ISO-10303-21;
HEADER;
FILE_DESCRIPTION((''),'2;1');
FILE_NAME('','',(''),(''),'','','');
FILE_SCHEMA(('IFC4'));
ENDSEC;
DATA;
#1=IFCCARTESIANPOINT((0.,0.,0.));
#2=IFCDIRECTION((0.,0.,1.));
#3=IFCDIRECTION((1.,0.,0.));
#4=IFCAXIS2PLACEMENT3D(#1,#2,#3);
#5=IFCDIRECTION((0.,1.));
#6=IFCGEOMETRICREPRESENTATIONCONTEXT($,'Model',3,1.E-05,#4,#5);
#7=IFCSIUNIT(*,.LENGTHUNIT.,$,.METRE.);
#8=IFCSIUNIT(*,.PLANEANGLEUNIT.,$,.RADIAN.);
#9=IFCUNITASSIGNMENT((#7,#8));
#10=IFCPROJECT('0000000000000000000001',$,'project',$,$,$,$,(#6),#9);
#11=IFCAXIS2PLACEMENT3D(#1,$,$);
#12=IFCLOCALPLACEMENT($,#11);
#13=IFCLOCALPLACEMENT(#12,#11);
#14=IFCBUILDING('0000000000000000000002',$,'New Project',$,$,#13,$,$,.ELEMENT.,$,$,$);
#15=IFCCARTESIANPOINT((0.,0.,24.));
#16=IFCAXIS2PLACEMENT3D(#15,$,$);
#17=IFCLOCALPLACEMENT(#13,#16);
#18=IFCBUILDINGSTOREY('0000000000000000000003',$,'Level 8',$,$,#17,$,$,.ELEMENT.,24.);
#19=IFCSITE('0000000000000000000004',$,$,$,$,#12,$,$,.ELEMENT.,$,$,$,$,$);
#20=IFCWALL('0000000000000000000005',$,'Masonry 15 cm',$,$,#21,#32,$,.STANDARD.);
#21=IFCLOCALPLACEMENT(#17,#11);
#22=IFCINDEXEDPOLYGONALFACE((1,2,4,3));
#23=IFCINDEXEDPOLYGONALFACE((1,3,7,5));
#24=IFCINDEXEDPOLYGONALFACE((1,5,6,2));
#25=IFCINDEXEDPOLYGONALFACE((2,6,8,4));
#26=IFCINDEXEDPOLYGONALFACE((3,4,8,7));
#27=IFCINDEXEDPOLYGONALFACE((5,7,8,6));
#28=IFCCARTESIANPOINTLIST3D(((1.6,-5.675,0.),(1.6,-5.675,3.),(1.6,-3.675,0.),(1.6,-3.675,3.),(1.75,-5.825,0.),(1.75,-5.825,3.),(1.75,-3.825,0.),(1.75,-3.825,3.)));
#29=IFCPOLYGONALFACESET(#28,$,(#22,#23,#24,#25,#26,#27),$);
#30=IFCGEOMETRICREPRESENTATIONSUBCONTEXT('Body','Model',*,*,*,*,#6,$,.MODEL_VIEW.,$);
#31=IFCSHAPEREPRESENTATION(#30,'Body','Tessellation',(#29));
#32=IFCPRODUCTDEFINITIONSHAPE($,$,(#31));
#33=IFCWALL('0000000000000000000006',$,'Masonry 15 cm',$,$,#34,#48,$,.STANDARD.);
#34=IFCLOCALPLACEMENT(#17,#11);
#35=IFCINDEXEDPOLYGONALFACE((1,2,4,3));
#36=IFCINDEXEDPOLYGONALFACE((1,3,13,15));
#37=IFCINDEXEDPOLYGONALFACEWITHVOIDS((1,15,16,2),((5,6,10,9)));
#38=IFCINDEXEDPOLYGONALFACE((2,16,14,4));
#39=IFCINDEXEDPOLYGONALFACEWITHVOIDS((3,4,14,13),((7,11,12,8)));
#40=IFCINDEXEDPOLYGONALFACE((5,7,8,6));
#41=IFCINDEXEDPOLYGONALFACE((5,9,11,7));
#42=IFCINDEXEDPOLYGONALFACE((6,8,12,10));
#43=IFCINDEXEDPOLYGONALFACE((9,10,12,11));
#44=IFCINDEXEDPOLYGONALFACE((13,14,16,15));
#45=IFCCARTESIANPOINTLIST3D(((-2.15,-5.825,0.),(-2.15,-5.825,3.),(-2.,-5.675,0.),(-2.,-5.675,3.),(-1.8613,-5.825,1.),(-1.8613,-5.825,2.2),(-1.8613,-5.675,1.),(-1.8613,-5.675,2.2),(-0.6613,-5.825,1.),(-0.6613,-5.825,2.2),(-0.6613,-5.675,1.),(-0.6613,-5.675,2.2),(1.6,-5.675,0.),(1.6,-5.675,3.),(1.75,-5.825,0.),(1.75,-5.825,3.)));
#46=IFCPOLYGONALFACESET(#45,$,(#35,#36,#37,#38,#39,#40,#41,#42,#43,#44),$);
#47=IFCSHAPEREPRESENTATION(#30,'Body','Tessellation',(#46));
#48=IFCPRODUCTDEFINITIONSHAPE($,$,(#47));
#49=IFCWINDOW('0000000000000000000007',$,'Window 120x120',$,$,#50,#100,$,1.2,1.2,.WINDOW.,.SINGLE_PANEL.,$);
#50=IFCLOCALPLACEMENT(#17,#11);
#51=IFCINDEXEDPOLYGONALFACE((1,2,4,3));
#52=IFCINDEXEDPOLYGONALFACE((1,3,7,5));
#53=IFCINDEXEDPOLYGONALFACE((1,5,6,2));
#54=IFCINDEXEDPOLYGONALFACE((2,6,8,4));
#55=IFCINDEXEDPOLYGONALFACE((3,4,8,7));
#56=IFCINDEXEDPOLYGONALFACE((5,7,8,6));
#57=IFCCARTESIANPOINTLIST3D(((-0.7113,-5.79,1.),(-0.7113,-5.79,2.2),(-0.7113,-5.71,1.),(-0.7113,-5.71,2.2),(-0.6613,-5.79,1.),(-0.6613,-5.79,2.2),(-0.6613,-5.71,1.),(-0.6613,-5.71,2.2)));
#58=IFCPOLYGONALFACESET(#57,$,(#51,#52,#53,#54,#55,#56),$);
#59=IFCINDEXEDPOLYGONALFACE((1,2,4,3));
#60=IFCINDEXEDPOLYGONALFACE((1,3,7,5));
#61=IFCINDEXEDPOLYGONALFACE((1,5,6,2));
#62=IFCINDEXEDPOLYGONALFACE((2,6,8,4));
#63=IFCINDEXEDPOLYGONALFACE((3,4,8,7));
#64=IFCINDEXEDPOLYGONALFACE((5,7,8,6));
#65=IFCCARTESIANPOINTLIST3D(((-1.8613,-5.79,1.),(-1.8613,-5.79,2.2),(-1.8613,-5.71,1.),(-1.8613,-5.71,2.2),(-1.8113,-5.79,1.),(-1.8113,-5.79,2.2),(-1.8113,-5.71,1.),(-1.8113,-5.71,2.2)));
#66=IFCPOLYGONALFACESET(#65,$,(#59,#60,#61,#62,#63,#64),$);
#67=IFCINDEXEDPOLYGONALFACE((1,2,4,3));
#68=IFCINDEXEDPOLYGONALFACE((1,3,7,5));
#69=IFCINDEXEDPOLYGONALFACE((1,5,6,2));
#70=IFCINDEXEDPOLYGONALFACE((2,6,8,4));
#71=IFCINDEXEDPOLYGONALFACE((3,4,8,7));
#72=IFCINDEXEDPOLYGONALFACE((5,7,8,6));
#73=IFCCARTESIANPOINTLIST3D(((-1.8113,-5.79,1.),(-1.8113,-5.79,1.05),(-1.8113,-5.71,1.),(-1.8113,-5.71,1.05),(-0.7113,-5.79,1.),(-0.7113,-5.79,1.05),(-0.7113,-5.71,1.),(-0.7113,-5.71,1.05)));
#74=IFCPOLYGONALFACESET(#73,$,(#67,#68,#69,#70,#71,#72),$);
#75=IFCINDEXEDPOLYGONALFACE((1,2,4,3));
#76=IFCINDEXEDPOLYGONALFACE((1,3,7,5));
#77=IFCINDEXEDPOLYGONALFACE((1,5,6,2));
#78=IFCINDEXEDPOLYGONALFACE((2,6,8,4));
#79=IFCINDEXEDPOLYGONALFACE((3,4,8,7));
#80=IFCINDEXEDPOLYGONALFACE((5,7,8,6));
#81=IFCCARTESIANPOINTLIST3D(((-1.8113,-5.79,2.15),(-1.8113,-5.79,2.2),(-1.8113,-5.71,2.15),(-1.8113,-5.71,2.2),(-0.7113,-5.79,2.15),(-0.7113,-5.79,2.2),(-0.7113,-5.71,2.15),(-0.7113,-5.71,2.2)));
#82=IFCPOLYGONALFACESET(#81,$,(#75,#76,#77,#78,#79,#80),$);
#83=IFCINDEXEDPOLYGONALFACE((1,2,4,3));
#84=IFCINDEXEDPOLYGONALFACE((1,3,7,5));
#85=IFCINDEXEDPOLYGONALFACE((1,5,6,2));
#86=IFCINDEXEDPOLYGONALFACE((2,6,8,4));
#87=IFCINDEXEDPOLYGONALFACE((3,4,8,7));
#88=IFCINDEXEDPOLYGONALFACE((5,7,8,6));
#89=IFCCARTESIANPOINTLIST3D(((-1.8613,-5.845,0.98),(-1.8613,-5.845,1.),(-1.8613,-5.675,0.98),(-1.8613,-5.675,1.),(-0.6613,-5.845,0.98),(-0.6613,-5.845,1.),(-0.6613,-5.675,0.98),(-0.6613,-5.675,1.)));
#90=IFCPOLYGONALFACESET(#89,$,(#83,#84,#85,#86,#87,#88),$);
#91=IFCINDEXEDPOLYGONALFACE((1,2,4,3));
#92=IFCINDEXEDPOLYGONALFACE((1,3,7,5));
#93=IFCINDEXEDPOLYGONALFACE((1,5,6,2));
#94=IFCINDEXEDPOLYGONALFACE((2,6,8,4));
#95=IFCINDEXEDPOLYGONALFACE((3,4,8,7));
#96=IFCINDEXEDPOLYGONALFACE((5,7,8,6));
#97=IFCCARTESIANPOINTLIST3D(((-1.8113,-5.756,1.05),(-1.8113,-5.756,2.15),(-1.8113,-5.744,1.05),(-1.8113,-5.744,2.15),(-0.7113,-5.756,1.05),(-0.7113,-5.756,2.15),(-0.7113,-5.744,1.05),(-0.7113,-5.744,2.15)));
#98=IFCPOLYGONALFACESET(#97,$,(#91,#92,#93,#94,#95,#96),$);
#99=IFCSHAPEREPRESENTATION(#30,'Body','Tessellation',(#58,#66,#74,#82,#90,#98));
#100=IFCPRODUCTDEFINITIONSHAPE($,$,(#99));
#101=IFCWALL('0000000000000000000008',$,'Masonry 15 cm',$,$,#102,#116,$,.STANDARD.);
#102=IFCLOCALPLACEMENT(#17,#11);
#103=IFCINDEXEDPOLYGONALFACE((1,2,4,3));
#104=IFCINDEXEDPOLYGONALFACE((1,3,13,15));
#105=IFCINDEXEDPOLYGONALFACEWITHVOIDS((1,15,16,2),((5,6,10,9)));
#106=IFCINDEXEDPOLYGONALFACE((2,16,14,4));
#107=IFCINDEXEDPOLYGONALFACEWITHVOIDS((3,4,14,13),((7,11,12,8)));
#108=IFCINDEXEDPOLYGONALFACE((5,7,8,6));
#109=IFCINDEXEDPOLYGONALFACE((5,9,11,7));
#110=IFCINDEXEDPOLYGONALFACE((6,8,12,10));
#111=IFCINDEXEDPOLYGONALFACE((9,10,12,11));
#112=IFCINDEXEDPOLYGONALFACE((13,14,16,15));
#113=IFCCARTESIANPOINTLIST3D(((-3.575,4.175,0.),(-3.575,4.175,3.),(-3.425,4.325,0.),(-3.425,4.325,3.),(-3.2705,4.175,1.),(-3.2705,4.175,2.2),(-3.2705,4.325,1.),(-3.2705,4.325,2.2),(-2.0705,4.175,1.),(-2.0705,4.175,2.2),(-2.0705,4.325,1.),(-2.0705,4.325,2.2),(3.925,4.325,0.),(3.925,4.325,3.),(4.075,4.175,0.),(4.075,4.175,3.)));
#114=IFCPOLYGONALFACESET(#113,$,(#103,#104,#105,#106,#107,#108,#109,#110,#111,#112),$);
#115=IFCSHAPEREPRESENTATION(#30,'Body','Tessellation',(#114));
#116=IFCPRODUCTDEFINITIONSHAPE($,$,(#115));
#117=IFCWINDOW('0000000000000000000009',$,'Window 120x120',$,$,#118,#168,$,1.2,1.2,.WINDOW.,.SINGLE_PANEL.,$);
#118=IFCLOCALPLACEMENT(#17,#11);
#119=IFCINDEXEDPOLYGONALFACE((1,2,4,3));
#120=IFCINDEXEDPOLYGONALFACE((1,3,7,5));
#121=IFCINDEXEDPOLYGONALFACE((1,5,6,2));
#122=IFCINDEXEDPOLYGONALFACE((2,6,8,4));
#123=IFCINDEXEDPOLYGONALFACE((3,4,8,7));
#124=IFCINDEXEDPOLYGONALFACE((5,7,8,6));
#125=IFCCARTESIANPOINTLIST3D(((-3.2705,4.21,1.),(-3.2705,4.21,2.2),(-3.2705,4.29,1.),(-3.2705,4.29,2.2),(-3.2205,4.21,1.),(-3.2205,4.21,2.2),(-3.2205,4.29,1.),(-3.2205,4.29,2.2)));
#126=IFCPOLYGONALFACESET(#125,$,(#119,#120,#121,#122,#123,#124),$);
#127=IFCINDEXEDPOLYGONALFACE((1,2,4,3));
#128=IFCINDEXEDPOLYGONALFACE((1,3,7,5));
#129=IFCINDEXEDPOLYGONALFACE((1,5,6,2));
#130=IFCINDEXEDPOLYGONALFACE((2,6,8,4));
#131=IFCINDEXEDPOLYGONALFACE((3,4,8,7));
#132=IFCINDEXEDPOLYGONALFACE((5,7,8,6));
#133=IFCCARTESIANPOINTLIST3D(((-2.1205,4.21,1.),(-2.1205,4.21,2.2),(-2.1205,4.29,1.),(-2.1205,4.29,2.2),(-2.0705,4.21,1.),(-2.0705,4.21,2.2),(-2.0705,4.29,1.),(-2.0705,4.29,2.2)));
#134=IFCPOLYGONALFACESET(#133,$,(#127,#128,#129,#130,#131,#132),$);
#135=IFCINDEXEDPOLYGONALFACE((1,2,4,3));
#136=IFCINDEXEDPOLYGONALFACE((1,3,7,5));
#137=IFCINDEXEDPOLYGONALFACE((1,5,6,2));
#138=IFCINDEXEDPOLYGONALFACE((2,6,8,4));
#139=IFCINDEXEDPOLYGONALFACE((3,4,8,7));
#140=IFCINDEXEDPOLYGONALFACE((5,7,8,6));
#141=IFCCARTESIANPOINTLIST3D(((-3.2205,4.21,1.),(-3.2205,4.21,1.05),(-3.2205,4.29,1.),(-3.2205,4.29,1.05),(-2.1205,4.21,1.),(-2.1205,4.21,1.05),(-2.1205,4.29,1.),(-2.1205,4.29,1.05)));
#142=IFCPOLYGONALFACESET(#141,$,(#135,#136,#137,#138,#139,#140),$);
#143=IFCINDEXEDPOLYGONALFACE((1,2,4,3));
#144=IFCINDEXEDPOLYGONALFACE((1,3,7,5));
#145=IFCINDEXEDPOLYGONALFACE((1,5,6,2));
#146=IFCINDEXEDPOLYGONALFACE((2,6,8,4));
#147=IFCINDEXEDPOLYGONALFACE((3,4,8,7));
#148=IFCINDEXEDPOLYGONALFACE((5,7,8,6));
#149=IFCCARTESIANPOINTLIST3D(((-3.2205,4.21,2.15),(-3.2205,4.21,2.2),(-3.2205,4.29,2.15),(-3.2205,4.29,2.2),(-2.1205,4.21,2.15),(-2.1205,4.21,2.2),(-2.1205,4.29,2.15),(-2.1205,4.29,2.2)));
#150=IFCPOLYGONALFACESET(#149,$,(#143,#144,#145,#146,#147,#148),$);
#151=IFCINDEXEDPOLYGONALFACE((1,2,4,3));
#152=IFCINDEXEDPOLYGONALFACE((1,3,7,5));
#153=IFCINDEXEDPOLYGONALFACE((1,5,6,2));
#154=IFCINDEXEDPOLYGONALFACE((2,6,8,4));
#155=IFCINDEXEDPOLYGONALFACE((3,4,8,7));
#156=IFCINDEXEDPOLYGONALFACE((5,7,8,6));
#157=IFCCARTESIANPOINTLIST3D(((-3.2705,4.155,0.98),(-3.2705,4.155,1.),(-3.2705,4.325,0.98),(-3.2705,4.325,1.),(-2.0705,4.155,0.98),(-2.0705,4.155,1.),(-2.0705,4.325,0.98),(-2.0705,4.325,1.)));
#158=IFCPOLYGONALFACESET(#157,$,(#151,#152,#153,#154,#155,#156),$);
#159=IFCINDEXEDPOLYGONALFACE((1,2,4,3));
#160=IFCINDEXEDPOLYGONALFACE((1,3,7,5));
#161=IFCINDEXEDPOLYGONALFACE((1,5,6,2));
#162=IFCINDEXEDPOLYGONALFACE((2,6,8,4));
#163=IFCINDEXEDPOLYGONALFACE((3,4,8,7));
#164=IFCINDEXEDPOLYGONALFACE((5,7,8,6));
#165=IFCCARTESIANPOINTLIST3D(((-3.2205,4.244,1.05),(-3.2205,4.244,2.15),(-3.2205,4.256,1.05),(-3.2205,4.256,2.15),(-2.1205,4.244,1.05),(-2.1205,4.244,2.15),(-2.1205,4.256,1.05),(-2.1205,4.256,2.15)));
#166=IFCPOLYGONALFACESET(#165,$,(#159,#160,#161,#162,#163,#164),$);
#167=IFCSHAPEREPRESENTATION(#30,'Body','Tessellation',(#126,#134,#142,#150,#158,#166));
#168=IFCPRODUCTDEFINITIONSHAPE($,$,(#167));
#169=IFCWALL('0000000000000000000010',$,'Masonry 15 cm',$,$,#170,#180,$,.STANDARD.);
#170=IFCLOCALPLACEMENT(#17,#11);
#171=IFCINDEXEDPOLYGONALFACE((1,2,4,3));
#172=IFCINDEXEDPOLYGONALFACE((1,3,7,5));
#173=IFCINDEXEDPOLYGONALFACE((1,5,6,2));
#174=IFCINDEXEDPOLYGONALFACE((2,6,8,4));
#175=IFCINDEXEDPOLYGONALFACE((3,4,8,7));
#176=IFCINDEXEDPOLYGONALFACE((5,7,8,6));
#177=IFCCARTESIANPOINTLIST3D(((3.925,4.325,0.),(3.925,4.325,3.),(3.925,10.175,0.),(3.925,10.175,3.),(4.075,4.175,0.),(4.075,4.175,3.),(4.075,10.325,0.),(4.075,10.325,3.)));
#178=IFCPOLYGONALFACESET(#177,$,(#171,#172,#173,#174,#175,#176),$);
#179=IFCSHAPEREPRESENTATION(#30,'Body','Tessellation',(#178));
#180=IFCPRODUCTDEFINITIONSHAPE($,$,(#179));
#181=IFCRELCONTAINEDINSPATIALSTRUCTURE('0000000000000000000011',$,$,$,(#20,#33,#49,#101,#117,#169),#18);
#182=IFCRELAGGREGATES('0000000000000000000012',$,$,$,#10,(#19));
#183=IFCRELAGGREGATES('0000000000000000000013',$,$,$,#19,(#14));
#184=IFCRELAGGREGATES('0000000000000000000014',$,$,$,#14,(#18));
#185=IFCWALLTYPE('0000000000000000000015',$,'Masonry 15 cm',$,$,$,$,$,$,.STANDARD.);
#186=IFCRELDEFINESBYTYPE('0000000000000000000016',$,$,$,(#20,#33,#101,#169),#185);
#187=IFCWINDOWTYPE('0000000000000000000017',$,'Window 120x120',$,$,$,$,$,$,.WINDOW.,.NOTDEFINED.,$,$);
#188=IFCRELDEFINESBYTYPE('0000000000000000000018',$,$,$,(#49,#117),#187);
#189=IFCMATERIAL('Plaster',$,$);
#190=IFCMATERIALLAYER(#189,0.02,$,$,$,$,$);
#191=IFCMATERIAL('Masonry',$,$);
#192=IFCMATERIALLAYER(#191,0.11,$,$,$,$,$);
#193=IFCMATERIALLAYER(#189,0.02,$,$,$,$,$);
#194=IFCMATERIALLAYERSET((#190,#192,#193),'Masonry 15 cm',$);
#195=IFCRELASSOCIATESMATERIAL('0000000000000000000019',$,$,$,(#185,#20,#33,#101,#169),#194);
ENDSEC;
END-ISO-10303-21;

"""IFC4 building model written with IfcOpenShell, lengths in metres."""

from ifc_helpers import new_model, si_unit, direction, frame, frame_2d, origin, origin_with_axes, place, context, subcontext, project, spatial, polyline, rectangle, outline, extrude, material, layer, layer_set, layer_usage, type_object, element, fill, save


model = new_model("IFC4")

# Units and contexts
model_context = context("Model", 3, precision=1e-05, world=origin_with_axes(), true_north=direction((0.0, 1.0)))
body_context = subcontext(model_context, "Body", "Model", "MODEL_VIEW")
ifc_project = project(units=[si_unit("LENGTHUNIT", "METRE"), si_unit("PLANEANGLEUNIT", "RADIAN")], contexts=[model_context])

# Site, building, storey
site_placement = place(None, origin())
site = spatial("IfcSite", under=ifc_project, at=site_placement, CompositionType="ELEMENT")
building_placement = place(site_placement, origin())
building = spatial("IfcBuilding", under=site, at=building_placement, Name="New Project", CompositionType="ELEMENT")
storey_placement = place(building_placement, frame((0.0, 0.0, 24.0)))
storey = spatial("IfcBuildingStorey", under=building, at=storey_placement, Name="Level 8", CompositionType="ELEMENT", Elevation=24.0)

# Shared definitions
ifc_material_1 = material(Name="Plaster")
ifc_layer_1 = layer(ifc_material_1, 0.02)
ifc_material_2 = material(Name="Masonry")
ifc_layer_2 = layer(ifc_material_2, 0.11)
ifc_layer_3 = layer(ifc_material_1, 0.02)
ifc_layer_set_1 = layer_set([ifc_layer_1, ifc_layer_2, ifc_layer_3], Name="Masonry 15 cm")
ifc_layer_usage_1 = layer_usage(ifc_layer_set_1, "AXIS2", "NEGATIVE", 0.075)
wall_type_1 = type_object("IfcWallType", Name="Masonry 15 cm", PredefinedType="STANDARD", material=ifc_layer_set_1)

# Shared definitions
window_type = type_object("IfcWindowType", Name="Window 120x120", PartitioningType="NOTDEFINED", PredefinedType="WINDOW")

# Wall
wall_1_placement = place(storey_placement, frame((1.675, -3.75, 0.0), z_axis=(0.0, 0.0, 1.0), x_axis=(0.0, -1.0, 0.0)))
element("IfcWall", 1, at=wall_1_placement, inside=storey, type_object=wall_type_1, material=ifc_layer_usage_1, Name="Masonry 15 cm", PredefinedType="STANDARD", context=body_context, shape_type="SweptSolid", body=[
    extrude(outline(polyline([(-0.075, -0.075), (1.925, -0.075), (2.075, 0.075), (0.075, 0.075), (-0.075, -0.075)])), origin(), (0.0, 0.0, 1.0), 3.0),
])

# Walls, openings, windows
wall_2_placement = place(storey_placement, frame((1.675, -5.75, 0.0), z_axis=(0.0, 0.0, 1.0), x_axis=(-1.0, 0.0, 0.0)))
wall_2 = element("IfcWall", 2, at=wall_2_placement, inside=storey, type_object=wall_type_1, material=ifc_layer_usage_1, Name="Masonry 15 cm", PredefinedType="STANDARD", context=body_context, shape_type="SweptSolid", body=[
    extrude(outline(polyline([(0.075, -0.075), (3.675, -0.075), (3.825, 0.075), (-0.075, 0.075), (0.075, -0.075)])), origin(), (0.0, 0.0, 1.0), 3.0),
])
opening_1_placement = place(wall_2_placement, frame((2.3363, 0.0, 1.0)))
opening_1 = element("IfcOpeningElement", 3, at=opening_1_placement, cuts=wall_2, PredefinedType="OPENING", context=body_context, shape_type="SweptSolid", body=[
    extrude(rectangle(XDim=1.2, YDim=0.25, at=frame_2d((0.6, 0.0))), origin(), (0.0, 0.0, 1.0), 1.2),
])
window_1_placement = place(opening_1_placement, origin())
window_1 = element("IfcWindow", 4, at=window_1_placement, inside=storey, type_object=window_type, Name="Window 120x120", OverallHeight=1.2, OverallWidth=1.2, PartitioningType="SINGLE_PANEL", PredefinedType="WINDOW", context=body_context, shape_type="SweptSolid", body=[
    extrude(outline(polyline([(0.0, -0.04), (0.05, -0.04), (0.05, 0.04), (0.0, 0.04), (0.0, -0.04)])), origin(), (0.0, 0.0, 1.0), 1.2),
    extrude(outline(polyline([(1.15, -0.04), (1.2, -0.04), (1.2, 0.04), (1.15, 0.04), (1.15, -0.04)])), origin(), (0.0, 0.0, 1.0), 1.2),
    extrude(outline(polyline([(0.05, -0.04), (1.15, -0.04), (1.15, 0.04), (0.05, 0.04), (0.05, -0.04)])), origin(), (0.0, 0.0, 1.0), 0.05),
    extrude(outline(polyline([(0.05, -0.04), (1.15, -0.04), (1.15, 0.04), (0.05, 0.04), (0.05, -0.04)])), frame((0.0, 0.0, 1.15)), (0.0, 0.0, 1.0), 0.05),
    extrude(outline(polyline([(0.0, -0.075), (1.2, -0.075), (1.2, 0.095), (0.0, 0.095), (0.0, -0.075)])), frame((0.0, 0.0, -0.02)), (0.0, 0.0, 1.0), 0.02),
    extrude(outline(polyline([(0.05, -0.006), (1.15, -0.006), (1.15, 0.006), (0.05, 0.006), (0.05, -0.006)])), frame((0.0, 0.0, 0.05)), (0.0, 0.0, 1.0), 1.1),
])
fill(opening_1, window_1)
wall_3_placement = place(storey_placement, frame((4.0, 4.25, 0.0), z_axis=(0.0, 0.0, 1.0), x_axis=(-1.0, 0.0, 0.0)))
wall_3 = element("IfcWall", 5, at=wall_3_placement, inside=storey, type_object=wall_type_1, material=ifc_layer_usage_1, Name="Masonry 15 cm", PredefinedType="STANDARD", context=body_context, shape_type="SweptSolid", body=[
    extrude(outline(polyline([(0.075, -0.075), (7.425, -0.075), (7.575, 0.075), (-0.075, 0.075), (0.075, -0.075)])), origin(), (0.0, 0.0, 1.0), 3.0),
])
opening_2_placement = place(wall_3_placement, frame((6.0705, 0.0, 1.0)))
opening_2 = element("IfcOpeningElement", 6, at=opening_2_placement, cuts=wall_3, PredefinedType="OPENING", context=body_context, shape_type="SweptSolid", body=[
    extrude(rectangle(XDim=1.2, YDim=0.25, at=frame_2d((0.6, 0.0))), origin(), (0.0, 0.0, 1.0), 1.2),
])
window_2_placement = place(opening_2_placement, origin())
window_2 = element("IfcWindow", 7, at=window_2_placement, inside=storey, type_object=window_type, Name="Window 120x120", OverallHeight=1.2, OverallWidth=1.2, PartitioningType="SINGLE_PANEL", PredefinedType="WINDOW", context=body_context, shape_type="SweptSolid", body=[
    extrude(outline(polyline([(1.2, 0.04), (1.15, 0.04), (1.15, -0.04), (1.2, -0.04), (1.2, 0.04)])), origin(), (0.0, 0.0, 1.0), 1.2),
    extrude(outline(polyline([(0.05, 0.04), (0.0, 0.04), (0.0, -0.04), (0.05, -0.04), (0.05, 0.04)])), origin(), (0.0, 0.0, 1.0), 1.2),
    extrude(outline(polyline([(1.15, 0.04), (0.05, 0.04), (0.05, -0.04), (1.15, -0.04), (1.15, 0.04)])), origin(), (0.0, 0.0, 1.0), 0.05),
    extrude(outline(polyline([(1.15, 0.04), (0.05, 0.04), (0.05, -0.04), (1.15, -0.04), (1.15, 0.04)])), frame((0.0, 0.0, 1.15)), (0.0, 0.0, 1.0), 0.05),
    extrude(outline(polyline([(1.2, 0.095), (0.0, 0.095), (0.0, -0.075), (1.2, -0.075), (1.2, 0.095)])), frame((0.0, 0.0, -0.02)), (0.0, 0.0, 1.0), 0.02),
    extrude(outline(polyline([(1.15, 0.006), (0.05, 0.006), (0.05, -0.006), (1.15, -0.006), (1.15, 0.006)])), frame((0.0, 0.0, 0.05)), (0.0, 0.0, 1.0), 1.1),
])
fill(opening_2, window_2)

# Wall
wall_4_placement = place(storey_placement, frame((4.0, 10.25, 0.0), z_axis=(0.0, 0.0, 1.0), x_axis=(0.0, -1.0, 0.0)))
element("IfcWall", 8, at=wall_4_placement, inside=storey, type_object=wall_type_1, material=ifc_layer_usage_1, Name="Masonry 15 cm", PredefinedType="STANDARD", context=body_context, shape_type="SweptSolid", body=[
    extrude(outline(polyline([(0.075, -0.075), (5.925, -0.075), (6.075, 0.075), (-0.075, 0.075), (0.075, -0.075)])), origin(), (0.0, 0.0, 1.0), 3.0),
])

save(model, "model.ifc")
